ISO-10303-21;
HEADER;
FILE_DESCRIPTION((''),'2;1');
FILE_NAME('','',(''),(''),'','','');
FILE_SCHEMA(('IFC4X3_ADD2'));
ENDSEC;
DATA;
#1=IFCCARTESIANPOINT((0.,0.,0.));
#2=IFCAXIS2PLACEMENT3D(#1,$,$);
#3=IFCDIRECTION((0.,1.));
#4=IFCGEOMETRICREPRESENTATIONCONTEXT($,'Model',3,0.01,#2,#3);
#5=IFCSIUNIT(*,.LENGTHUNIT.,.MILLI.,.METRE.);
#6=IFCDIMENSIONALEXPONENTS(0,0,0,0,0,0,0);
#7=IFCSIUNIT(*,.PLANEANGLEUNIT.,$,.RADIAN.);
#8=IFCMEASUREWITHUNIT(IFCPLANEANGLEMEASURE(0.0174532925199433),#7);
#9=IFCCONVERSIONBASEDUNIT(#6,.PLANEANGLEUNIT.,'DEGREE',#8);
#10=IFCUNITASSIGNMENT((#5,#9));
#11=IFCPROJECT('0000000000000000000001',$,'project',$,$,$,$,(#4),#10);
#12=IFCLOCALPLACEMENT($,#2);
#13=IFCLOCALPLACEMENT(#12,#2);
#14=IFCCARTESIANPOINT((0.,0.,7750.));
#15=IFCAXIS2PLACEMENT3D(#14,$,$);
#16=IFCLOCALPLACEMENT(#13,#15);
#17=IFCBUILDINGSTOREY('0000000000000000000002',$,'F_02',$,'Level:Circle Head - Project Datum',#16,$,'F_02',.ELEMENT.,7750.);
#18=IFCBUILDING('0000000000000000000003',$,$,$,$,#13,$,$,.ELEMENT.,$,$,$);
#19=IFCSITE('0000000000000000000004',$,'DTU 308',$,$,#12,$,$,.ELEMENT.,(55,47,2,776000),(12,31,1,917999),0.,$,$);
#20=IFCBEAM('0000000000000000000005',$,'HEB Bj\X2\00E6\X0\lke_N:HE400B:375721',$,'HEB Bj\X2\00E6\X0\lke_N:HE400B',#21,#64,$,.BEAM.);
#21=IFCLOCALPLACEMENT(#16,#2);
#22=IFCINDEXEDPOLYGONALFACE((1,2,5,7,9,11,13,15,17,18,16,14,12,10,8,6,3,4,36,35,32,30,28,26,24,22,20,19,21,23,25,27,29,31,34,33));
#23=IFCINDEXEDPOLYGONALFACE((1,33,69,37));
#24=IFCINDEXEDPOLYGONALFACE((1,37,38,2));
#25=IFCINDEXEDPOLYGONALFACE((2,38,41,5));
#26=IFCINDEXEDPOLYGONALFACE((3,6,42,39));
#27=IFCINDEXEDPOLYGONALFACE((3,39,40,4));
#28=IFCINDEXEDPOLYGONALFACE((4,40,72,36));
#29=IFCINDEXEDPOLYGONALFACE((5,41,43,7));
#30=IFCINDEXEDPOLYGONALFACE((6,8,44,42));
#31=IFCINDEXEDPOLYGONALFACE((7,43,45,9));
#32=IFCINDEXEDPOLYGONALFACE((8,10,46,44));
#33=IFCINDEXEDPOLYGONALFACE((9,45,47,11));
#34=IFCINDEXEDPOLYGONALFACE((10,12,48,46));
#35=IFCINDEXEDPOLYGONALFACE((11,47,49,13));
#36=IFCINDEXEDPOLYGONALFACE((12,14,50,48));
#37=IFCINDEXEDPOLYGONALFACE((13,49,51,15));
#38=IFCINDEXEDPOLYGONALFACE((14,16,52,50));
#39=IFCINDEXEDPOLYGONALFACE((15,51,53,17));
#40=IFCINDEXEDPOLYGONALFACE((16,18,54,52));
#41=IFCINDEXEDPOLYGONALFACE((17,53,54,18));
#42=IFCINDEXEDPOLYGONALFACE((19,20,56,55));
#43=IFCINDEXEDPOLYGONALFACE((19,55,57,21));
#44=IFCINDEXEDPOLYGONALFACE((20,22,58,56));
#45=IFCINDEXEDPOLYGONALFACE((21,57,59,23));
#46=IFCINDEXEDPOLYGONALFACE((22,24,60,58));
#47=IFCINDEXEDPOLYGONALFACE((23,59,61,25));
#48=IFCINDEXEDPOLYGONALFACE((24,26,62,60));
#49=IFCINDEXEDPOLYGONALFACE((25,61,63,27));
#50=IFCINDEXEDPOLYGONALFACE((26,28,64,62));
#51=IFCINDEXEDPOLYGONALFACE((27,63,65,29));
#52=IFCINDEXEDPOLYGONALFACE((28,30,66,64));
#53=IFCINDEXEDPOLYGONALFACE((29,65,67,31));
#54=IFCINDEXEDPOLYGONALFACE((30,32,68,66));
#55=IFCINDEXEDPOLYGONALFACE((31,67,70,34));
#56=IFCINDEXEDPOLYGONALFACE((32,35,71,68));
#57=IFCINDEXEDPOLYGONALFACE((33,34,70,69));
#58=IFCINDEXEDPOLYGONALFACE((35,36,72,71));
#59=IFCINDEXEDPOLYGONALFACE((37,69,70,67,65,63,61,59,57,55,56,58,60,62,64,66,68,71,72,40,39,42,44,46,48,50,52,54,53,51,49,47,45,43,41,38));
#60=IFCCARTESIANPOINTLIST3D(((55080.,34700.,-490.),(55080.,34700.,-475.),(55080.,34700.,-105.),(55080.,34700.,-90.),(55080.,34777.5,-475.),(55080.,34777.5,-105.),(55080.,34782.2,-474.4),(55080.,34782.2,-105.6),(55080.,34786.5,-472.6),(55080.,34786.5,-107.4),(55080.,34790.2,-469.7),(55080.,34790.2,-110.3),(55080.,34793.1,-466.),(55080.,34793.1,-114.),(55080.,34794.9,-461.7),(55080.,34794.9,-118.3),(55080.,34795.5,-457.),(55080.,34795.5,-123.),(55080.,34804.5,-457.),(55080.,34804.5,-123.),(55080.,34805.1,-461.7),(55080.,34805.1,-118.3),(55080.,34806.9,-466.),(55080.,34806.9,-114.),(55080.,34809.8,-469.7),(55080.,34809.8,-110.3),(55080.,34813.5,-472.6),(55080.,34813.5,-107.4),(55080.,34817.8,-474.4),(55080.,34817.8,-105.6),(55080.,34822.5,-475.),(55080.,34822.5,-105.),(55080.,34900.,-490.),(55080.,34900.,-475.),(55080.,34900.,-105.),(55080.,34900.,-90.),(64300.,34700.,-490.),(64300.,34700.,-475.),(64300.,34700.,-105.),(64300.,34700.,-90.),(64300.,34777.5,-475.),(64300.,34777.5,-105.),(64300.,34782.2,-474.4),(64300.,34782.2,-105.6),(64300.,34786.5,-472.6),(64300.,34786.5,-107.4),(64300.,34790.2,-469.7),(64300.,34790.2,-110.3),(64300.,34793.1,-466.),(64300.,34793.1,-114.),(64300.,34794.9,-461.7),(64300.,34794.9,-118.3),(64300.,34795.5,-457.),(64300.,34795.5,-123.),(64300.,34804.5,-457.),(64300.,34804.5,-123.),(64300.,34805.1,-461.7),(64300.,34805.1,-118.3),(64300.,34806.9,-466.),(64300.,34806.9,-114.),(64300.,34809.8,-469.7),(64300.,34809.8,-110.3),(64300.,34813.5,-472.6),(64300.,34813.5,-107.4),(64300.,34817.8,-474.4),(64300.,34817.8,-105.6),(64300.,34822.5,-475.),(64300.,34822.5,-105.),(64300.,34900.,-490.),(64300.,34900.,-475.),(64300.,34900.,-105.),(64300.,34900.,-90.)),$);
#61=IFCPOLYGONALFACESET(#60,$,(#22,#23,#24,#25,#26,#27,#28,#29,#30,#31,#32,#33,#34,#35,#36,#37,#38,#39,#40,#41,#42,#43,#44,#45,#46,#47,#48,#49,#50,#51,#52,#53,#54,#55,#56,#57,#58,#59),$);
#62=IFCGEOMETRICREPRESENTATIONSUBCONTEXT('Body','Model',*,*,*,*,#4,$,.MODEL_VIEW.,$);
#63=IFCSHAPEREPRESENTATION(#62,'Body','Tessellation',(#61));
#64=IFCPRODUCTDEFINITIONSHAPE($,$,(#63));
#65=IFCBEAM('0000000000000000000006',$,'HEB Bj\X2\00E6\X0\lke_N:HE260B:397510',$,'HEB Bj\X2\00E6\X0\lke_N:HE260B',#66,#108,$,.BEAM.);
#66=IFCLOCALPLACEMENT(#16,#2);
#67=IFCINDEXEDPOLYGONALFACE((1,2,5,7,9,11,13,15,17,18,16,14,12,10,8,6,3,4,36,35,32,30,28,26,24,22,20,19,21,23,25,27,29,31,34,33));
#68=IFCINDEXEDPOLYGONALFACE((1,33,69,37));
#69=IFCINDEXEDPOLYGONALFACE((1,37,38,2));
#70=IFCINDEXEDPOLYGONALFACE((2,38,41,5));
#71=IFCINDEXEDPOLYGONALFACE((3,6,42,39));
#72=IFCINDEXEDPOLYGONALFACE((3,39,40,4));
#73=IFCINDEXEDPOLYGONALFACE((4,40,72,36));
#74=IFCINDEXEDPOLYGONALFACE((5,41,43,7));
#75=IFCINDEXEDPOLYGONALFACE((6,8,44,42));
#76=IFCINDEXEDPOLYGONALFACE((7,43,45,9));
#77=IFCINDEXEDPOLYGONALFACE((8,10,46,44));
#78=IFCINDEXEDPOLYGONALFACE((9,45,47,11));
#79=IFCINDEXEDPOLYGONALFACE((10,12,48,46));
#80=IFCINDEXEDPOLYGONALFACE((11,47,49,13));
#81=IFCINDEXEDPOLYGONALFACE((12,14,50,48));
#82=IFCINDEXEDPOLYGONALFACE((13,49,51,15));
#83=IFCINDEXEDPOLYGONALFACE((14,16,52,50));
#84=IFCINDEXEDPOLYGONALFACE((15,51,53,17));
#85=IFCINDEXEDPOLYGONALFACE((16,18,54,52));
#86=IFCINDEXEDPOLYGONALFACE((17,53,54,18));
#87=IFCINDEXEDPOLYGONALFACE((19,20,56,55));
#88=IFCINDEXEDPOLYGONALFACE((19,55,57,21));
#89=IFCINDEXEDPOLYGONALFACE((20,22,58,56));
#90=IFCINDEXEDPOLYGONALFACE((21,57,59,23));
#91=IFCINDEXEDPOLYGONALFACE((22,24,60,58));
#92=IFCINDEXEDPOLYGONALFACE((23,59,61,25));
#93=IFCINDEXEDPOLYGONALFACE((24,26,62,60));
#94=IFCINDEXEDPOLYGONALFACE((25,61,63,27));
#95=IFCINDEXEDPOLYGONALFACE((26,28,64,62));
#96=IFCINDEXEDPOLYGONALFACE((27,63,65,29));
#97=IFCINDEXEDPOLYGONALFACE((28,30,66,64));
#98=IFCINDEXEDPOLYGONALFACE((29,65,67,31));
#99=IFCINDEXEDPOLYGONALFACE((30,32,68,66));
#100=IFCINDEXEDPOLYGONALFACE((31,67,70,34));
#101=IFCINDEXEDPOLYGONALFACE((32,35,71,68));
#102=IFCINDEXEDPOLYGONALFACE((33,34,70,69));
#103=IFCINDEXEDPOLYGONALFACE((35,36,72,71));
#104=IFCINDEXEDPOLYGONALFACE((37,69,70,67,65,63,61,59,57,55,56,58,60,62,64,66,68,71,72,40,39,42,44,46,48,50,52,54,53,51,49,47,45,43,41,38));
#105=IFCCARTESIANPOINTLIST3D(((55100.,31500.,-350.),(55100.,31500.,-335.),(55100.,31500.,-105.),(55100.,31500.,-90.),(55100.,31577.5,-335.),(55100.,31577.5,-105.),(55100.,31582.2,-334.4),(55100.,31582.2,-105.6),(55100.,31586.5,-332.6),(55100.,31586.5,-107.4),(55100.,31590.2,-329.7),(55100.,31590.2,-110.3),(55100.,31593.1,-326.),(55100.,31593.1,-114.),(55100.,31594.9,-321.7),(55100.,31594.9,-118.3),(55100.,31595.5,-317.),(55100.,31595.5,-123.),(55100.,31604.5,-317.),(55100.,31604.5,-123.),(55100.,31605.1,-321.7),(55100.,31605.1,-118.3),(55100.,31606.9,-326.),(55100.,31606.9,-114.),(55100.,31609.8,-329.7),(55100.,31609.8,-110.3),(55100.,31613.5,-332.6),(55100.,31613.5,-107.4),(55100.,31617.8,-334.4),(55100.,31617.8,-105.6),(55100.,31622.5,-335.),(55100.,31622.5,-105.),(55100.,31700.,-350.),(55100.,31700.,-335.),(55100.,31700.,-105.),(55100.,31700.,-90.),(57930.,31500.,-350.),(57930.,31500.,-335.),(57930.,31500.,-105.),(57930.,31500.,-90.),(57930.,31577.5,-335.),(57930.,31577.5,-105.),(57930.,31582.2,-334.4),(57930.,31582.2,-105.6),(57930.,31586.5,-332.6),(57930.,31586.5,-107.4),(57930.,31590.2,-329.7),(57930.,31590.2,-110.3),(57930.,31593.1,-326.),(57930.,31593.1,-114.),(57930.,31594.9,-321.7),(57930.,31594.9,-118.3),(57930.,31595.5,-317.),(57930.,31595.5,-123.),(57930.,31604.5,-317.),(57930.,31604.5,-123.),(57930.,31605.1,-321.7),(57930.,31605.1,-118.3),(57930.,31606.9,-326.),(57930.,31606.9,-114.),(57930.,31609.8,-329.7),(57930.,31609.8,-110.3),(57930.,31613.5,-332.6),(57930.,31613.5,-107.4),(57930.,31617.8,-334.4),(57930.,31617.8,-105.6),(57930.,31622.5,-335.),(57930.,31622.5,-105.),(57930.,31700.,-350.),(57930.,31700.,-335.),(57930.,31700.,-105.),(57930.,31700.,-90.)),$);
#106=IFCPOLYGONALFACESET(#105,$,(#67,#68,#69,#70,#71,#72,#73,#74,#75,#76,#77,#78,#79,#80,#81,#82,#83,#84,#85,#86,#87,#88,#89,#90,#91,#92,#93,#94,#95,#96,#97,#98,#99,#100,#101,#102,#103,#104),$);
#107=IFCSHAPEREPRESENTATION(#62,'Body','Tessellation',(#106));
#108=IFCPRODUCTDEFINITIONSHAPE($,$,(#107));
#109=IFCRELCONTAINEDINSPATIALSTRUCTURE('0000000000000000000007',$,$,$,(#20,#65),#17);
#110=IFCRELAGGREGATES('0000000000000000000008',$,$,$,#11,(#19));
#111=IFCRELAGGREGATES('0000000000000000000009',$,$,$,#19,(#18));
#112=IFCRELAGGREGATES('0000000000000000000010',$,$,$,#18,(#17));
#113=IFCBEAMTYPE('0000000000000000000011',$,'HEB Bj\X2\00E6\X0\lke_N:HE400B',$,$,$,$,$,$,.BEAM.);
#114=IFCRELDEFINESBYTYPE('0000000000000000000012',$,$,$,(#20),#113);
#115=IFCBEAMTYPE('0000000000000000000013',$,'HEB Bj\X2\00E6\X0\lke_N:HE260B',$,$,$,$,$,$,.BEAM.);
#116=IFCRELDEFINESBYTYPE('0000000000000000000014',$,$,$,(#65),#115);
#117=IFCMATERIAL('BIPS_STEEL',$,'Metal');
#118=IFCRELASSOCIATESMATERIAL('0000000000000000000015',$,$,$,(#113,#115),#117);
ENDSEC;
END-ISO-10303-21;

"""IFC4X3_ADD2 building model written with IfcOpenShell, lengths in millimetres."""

from ifc_helpers import new_model, entity, si_unit, converted_unit, direction, frame, frame_2d, origin, place, context, subcontext, project, spatial, polyline, circle_curve, parameter, trimmed, segment, composite_curve, i_section, outline, extrude, source, transform, mapped, material, material_profile, profile_set, type_object, element, save


model = new_model("IFC4X3_ADD2")

# Units and contexts
model_context = context("Model", 3, precision=0.01, world=origin(), true_north=direction((0.0, 1.0)))
body_context = subcontext(model_context, "Body", "Model", "MODEL_VIEW")
ifc_project = project(units=[si_unit("LENGTHUNIT", "METRE", prefix="MILLI"), converted_unit("PLANEANGLEUNIT", "DEGREE", entity("IfcPlaneAngleMeasure", 0.0174532925199433), si_unit("PLANEANGLEUNIT", "RADIAN"), dimensions=[0, 0, 0, 0, 0, 0, 0])], contexts=[model_context])

# Site, building, storey
site_placement = place(None, origin())
site = spatial("IfcSite", under=ifc_project, at=site_placement, Name="DTU 308", CompositionType="ELEMENT", RefLatitude=(55, 47, 2, 776000), RefLongitude=(12, 31, 1, 917999), RefElevation=0.0)
building_placement = place(site_placement, origin())
building = spatial("IfcBuilding", under=site, at=building_placement, CompositionType="ELEMENT")
storey_placement = place(building_placement, frame((0.0, 0.0, 7750.0)))
storey = spatial("IfcBuildingStorey", under=building, at=storey_placement, Name="F_02", ObjectType="Level:Circle Head - Project Datum", LongName="F_02", CompositionType="ELEMENT", Elevation=7750.0)

# Shared definitions
ifc_material = material(Name="BIPS_STEEL", Category="Metal")

# Beams
ifc_material_profile_1 = material_profile(ifc_material, outline(composite_curve([segment(polyline([(-100.0, -185.0), (-100.0, -200.0)]), True, "CONTINUOUS"), segment(polyline([(-100.0, -200.0), (100.0, -200.0)]), True, "CONTINUOUS"), segment(polyline([(100.0, -200.0), (100.0, -185.0)]), True, "CONTINUOUS"), segment(polyline([(100.0, -185.0), (22.5, -185.0)]), True, "CONTINUOUS"), segment(trimmed(circle_curve(frame_2d((22.5, -167.0), x_axis=(1.0, 0.0)), 18.0), [parameter(180.0)], [parameter(270.0)], True, "PARAMETER"), False, "CONTINUOUS"), segment(polyline([(4.5, -167.0), (4.5, 167.0)]), True, "CONTINUOUS"), segment(trimmed(circle_curve(frame_2d((22.5, 167.0), x_axis=(1.0, 0.0)), 18.0), [parameter(90.0)], [parameter(180.0)], True, "PARAMETER"), False, "CONTINUOUS"), segment(polyline([(22.5, 185.0), (100.0, 185.0)]), True, "CONTINUOUS"), segment(polyline([(100.0, 185.0), (100.0, 200.0)]), True, "CONTINUOUS"), segment(polyline([(100.0, 200.0), (-100.0, 200.0)]), True, "CONTINUOUS"), segment(polyline([(-100.0, 200.0), (-100.0, 185.0)]), True, "CONTINUOUS"), segment(polyline([(-100.0, 185.0), (-22.5, 185.0)]), True, "CONTINUOUS"), segment(trimmed(circle_curve(frame_2d((-22.5, 167.0), x_axis=(1.0, 0.0)), 18.0), [parameter(360.0)], [parameter(90.0)], True, "PARAMETER"), False, "CONTINUOUS"), segment(polyline([(-4.5, 167.0), (-4.5, -167.0)]), True, "CONTINUOUS"), segment(trimmed(circle_curve(frame_2d((-22.5, -167.0), x_axis=(1.0, 0.0)), 18.0), [parameter(270.0)], [parameter(360.0)], True, "PARAMETER"), False, "CONTINUOUS"), segment(polyline([(-22.5, -185.0), (-100.0, -185.0)]), True, "CONTINUOUS")], self_intersect=False)), Name="HE400B")
ifc_profile_set_1 = profile_set([ifc_material_profile_1], Name="HE400B")
beam_type_1 = type_object("IfcBeamType", Name="HEB Bjælke_N:HE400B", PredefinedType="BEAM", material=ifc_profile_set_1)
ifc_material_profile_2 = material_profile(ifc_material, i_section(OverallWidth=200.0, OverallDepth=260.0, WebThickness=9.0, FlangeThickness=15.0, FilletRadius=18.0, at=frame_2d((0.0, 0.0), x_axis=(1.0, 0.0))), Name="HE260B")
ifc_profile_set_2 = profile_set([ifc_material_profile_2], Name="HE260B")
beam_type_2 = type_object("IfcBeamType", Name="HEB Bjælke_N:HE260B", PredefinedType="BEAM", material=ifc_profile_set_2)
shared_shape_1 = source(origin(), body_context, "Body", "SweptSolid", [
    extrude(outline(composite_curve([segment(polyline([(-100.0, -185.0), (-100.0, -200.0)]), True, "CONTINUOUS"), segment(polyline([(-100.0, -200.0), (100.0, -200.0)]), True, "CONTINUOUS"), segment(polyline([(100.0, -200.0), (100.0, -185.0)]), True, "CONTINUOUS"), segment(polyline([(100.0, -185.0), (22.5, -185.0)]), True, "CONTINUOUS"), segment(trimmed(circle_curve(frame_2d((22.5, -167.0), x_axis=(1.0, 0.0)), 18.0), [parameter(180.0)], [parameter(270.0)], True, "PARAMETER"), False, "CONTINUOUS"), segment(polyline([(4.5, -167.0), (4.5, 167.0)]), True, "CONTINUOUS"), segment(trimmed(circle_curve(frame_2d((22.5, 167.0), x_axis=(1.0, 0.0)), 18.0), [parameter(90.0)], [parameter(180.0)], True, "PARAMETER"), False, "CONTINUOUS"), segment(polyline([(22.5, 185.0), (100.0, 185.0)]), True, "CONTINUOUS"), segment(polyline([(100.0, 185.0), (100.0, 200.0)]), True, "CONTINUOUS"), segment(polyline([(100.0, 200.0), (-100.0, 200.0)]), True, "CONTINUOUS"), segment(polyline([(-100.0, 200.0), (-100.0, 185.0)]), True, "CONTINUOUS"), segment(polyline([(-100.0, 185.0), (-22.5, 185.0)]), True, "CONTINUOUS"), segment(trimmed(circle_curve(frame_2d((-22.5, 167.0), x_axis=(1.0, 0.0)), 18.0), [parameter(360.0)], [parameter(90.0)], True, "PARAMETER"), False, "CONTINUOUS"), segment(polyline([(-4.5, 167.0), (-4.5, -167.0)]), True, "CONTINUOUS"), segment(trimmed(circle_curve(frame_2d((-22.5, -167.0), x_axis=(1.0, 0.0)), 18.0), [parameter(270.0)], [parameter(360.0)], True, "PARAMETER"), False, "CONTINUOUS"), segment(polyline([(-22.5, -185.0), (-100.0, -185.0)]), True, "CONTINUOUS")], self_intersect=False)), frame((-4610.0, 0.0, 0.0), z_axis=(-1.0, 0.0, 0.0), x_axis=(0.0, -1.0, 0.0)), (0.0, 0.0, -1.0), 9220.0),
])
beam_1_placement = place(storey_placement, frame((59690.0, 34800.0, -290.0)))
element("IfcBeam", 1, at=beam_1_placement, inside=storey, type_object=beam_type_1, Name="HEB Bjælke_N:HE400B:375721", ObjectType="HEB Bjælke_N:HE400B", PredefinedType="BEAM", context=body_context, shape_type="MappedRepresentation", body=[
    mapped(shared_shape_1, transform((0.0, 0.0, 0.0), scale=1.0)),
])
shared_shape_2 = source(origin(), body_context, "Body", "SweptSolid", [
    extrude(outline(composite_curve([segment(polyline([(-100.0, -115.0), (-100.0, -130.0)]), True, "CONTINUOUS"), segment(polyline([(-100.0, -130.0), (100.0, -130.0)]), True, "CONTINUOUS"), segment(polyline([(100.0, -130.0), (100.0, -115.0)]), True, "CONTINUOUS"), segment(polyline([(100.0, -115.0), (22.5, -115.0)]), True, "CONTINUOUS"), segment(trimmed(circle_curve(frame_2d((22.5, -97.0), x_axis=(0.0, -1.0)), 18.0), [parameter(270.0)], [parameter(360.0)], True, "PARAMETER"), False, "CONTINUOUS"), segment(polyline([(4.5, -97.0), (4.5, 97.0)]), True, "CONTINUOUS"), segment(trimmed(circle_curve(frame_2d((22.5, 97.0), x_axis=(-1.0, 0.0)), 18.0), [parameter(270.0)], [parameter(360.0)], True, "PARAMETER"), False, "CONTINUOUS"), segment(polyline([(22.5, 115.0), (100.0, 115.0)]), True, "CONTINUOUS"), segment(polyline([(100.0, 115.0), (100.0, 130.0)]), True, "CONTINUOUS"), segment(polyline([(100.0, 130.0), (-100.0, 130.0)]), True, "CONTINUOUS"), segment(polyline([(-100.0, 130.0), (-100.0, 115.0)]), True, "CONTINUOUS"), segment(polyline([(-100.0, 115.0), (-22.5, 115.0)]), True, "CONTINUOUS"), segment(trimmed(circle_curve(frame_2d((-22.5, 97.0), x_axis=(0.0, 1.0)), 18.0), [parameter(270.0)], [parameter(0.0)], True, "PARAMETER"), False, "CONTINUOUS"), segment(polyline([(-4.5, 97.0), (-4.5, -97.0)]), True, "CONTINUOUS"), segment(trimmed(circle_curve(frame_2d((-22.5, -97.0), x_axis=(1.0, 0.0)), 18.0), [parameter(270.0)], [parameter(0.0)], True, "PARAMETER"), False, "CONTINUOUS"), segment(polyline([(-22.5, -115.0), (-100.0, -115.0)]), True, "CONTINUOUS")], self_intersect=False)), frame((-1315.0, 0.0, 0.0), z_axis=(-1.0, 0.0, 0.0), x_axis=(0.0, -1.0, 0.0)), (0.0, 0.0, -1.0), 2830.0),
])
beam_2_placement = place(storey_placement, frame((56615.0, 31600.0, -220.0), z_axis=(0.0, 0.0, 1.0), x_axis=(-1.0, 0.0, 0.0)))
element("IfcBeam", 2, at=beam_2_placement, inside=storey, type_object=beam_type_2, Name="HEB Bjælke_N:HE260B:397510", ObjectType="HEB Bjælke_N:HE260B", PredefinedType="BEAM", context=body_context, shape_type="MappedRepresentation", body=[
    mapped(shared_shape_2, transform((0.0, 0.0, 0.0), scale=1.0)),
])

save(model, "model.ifc")
